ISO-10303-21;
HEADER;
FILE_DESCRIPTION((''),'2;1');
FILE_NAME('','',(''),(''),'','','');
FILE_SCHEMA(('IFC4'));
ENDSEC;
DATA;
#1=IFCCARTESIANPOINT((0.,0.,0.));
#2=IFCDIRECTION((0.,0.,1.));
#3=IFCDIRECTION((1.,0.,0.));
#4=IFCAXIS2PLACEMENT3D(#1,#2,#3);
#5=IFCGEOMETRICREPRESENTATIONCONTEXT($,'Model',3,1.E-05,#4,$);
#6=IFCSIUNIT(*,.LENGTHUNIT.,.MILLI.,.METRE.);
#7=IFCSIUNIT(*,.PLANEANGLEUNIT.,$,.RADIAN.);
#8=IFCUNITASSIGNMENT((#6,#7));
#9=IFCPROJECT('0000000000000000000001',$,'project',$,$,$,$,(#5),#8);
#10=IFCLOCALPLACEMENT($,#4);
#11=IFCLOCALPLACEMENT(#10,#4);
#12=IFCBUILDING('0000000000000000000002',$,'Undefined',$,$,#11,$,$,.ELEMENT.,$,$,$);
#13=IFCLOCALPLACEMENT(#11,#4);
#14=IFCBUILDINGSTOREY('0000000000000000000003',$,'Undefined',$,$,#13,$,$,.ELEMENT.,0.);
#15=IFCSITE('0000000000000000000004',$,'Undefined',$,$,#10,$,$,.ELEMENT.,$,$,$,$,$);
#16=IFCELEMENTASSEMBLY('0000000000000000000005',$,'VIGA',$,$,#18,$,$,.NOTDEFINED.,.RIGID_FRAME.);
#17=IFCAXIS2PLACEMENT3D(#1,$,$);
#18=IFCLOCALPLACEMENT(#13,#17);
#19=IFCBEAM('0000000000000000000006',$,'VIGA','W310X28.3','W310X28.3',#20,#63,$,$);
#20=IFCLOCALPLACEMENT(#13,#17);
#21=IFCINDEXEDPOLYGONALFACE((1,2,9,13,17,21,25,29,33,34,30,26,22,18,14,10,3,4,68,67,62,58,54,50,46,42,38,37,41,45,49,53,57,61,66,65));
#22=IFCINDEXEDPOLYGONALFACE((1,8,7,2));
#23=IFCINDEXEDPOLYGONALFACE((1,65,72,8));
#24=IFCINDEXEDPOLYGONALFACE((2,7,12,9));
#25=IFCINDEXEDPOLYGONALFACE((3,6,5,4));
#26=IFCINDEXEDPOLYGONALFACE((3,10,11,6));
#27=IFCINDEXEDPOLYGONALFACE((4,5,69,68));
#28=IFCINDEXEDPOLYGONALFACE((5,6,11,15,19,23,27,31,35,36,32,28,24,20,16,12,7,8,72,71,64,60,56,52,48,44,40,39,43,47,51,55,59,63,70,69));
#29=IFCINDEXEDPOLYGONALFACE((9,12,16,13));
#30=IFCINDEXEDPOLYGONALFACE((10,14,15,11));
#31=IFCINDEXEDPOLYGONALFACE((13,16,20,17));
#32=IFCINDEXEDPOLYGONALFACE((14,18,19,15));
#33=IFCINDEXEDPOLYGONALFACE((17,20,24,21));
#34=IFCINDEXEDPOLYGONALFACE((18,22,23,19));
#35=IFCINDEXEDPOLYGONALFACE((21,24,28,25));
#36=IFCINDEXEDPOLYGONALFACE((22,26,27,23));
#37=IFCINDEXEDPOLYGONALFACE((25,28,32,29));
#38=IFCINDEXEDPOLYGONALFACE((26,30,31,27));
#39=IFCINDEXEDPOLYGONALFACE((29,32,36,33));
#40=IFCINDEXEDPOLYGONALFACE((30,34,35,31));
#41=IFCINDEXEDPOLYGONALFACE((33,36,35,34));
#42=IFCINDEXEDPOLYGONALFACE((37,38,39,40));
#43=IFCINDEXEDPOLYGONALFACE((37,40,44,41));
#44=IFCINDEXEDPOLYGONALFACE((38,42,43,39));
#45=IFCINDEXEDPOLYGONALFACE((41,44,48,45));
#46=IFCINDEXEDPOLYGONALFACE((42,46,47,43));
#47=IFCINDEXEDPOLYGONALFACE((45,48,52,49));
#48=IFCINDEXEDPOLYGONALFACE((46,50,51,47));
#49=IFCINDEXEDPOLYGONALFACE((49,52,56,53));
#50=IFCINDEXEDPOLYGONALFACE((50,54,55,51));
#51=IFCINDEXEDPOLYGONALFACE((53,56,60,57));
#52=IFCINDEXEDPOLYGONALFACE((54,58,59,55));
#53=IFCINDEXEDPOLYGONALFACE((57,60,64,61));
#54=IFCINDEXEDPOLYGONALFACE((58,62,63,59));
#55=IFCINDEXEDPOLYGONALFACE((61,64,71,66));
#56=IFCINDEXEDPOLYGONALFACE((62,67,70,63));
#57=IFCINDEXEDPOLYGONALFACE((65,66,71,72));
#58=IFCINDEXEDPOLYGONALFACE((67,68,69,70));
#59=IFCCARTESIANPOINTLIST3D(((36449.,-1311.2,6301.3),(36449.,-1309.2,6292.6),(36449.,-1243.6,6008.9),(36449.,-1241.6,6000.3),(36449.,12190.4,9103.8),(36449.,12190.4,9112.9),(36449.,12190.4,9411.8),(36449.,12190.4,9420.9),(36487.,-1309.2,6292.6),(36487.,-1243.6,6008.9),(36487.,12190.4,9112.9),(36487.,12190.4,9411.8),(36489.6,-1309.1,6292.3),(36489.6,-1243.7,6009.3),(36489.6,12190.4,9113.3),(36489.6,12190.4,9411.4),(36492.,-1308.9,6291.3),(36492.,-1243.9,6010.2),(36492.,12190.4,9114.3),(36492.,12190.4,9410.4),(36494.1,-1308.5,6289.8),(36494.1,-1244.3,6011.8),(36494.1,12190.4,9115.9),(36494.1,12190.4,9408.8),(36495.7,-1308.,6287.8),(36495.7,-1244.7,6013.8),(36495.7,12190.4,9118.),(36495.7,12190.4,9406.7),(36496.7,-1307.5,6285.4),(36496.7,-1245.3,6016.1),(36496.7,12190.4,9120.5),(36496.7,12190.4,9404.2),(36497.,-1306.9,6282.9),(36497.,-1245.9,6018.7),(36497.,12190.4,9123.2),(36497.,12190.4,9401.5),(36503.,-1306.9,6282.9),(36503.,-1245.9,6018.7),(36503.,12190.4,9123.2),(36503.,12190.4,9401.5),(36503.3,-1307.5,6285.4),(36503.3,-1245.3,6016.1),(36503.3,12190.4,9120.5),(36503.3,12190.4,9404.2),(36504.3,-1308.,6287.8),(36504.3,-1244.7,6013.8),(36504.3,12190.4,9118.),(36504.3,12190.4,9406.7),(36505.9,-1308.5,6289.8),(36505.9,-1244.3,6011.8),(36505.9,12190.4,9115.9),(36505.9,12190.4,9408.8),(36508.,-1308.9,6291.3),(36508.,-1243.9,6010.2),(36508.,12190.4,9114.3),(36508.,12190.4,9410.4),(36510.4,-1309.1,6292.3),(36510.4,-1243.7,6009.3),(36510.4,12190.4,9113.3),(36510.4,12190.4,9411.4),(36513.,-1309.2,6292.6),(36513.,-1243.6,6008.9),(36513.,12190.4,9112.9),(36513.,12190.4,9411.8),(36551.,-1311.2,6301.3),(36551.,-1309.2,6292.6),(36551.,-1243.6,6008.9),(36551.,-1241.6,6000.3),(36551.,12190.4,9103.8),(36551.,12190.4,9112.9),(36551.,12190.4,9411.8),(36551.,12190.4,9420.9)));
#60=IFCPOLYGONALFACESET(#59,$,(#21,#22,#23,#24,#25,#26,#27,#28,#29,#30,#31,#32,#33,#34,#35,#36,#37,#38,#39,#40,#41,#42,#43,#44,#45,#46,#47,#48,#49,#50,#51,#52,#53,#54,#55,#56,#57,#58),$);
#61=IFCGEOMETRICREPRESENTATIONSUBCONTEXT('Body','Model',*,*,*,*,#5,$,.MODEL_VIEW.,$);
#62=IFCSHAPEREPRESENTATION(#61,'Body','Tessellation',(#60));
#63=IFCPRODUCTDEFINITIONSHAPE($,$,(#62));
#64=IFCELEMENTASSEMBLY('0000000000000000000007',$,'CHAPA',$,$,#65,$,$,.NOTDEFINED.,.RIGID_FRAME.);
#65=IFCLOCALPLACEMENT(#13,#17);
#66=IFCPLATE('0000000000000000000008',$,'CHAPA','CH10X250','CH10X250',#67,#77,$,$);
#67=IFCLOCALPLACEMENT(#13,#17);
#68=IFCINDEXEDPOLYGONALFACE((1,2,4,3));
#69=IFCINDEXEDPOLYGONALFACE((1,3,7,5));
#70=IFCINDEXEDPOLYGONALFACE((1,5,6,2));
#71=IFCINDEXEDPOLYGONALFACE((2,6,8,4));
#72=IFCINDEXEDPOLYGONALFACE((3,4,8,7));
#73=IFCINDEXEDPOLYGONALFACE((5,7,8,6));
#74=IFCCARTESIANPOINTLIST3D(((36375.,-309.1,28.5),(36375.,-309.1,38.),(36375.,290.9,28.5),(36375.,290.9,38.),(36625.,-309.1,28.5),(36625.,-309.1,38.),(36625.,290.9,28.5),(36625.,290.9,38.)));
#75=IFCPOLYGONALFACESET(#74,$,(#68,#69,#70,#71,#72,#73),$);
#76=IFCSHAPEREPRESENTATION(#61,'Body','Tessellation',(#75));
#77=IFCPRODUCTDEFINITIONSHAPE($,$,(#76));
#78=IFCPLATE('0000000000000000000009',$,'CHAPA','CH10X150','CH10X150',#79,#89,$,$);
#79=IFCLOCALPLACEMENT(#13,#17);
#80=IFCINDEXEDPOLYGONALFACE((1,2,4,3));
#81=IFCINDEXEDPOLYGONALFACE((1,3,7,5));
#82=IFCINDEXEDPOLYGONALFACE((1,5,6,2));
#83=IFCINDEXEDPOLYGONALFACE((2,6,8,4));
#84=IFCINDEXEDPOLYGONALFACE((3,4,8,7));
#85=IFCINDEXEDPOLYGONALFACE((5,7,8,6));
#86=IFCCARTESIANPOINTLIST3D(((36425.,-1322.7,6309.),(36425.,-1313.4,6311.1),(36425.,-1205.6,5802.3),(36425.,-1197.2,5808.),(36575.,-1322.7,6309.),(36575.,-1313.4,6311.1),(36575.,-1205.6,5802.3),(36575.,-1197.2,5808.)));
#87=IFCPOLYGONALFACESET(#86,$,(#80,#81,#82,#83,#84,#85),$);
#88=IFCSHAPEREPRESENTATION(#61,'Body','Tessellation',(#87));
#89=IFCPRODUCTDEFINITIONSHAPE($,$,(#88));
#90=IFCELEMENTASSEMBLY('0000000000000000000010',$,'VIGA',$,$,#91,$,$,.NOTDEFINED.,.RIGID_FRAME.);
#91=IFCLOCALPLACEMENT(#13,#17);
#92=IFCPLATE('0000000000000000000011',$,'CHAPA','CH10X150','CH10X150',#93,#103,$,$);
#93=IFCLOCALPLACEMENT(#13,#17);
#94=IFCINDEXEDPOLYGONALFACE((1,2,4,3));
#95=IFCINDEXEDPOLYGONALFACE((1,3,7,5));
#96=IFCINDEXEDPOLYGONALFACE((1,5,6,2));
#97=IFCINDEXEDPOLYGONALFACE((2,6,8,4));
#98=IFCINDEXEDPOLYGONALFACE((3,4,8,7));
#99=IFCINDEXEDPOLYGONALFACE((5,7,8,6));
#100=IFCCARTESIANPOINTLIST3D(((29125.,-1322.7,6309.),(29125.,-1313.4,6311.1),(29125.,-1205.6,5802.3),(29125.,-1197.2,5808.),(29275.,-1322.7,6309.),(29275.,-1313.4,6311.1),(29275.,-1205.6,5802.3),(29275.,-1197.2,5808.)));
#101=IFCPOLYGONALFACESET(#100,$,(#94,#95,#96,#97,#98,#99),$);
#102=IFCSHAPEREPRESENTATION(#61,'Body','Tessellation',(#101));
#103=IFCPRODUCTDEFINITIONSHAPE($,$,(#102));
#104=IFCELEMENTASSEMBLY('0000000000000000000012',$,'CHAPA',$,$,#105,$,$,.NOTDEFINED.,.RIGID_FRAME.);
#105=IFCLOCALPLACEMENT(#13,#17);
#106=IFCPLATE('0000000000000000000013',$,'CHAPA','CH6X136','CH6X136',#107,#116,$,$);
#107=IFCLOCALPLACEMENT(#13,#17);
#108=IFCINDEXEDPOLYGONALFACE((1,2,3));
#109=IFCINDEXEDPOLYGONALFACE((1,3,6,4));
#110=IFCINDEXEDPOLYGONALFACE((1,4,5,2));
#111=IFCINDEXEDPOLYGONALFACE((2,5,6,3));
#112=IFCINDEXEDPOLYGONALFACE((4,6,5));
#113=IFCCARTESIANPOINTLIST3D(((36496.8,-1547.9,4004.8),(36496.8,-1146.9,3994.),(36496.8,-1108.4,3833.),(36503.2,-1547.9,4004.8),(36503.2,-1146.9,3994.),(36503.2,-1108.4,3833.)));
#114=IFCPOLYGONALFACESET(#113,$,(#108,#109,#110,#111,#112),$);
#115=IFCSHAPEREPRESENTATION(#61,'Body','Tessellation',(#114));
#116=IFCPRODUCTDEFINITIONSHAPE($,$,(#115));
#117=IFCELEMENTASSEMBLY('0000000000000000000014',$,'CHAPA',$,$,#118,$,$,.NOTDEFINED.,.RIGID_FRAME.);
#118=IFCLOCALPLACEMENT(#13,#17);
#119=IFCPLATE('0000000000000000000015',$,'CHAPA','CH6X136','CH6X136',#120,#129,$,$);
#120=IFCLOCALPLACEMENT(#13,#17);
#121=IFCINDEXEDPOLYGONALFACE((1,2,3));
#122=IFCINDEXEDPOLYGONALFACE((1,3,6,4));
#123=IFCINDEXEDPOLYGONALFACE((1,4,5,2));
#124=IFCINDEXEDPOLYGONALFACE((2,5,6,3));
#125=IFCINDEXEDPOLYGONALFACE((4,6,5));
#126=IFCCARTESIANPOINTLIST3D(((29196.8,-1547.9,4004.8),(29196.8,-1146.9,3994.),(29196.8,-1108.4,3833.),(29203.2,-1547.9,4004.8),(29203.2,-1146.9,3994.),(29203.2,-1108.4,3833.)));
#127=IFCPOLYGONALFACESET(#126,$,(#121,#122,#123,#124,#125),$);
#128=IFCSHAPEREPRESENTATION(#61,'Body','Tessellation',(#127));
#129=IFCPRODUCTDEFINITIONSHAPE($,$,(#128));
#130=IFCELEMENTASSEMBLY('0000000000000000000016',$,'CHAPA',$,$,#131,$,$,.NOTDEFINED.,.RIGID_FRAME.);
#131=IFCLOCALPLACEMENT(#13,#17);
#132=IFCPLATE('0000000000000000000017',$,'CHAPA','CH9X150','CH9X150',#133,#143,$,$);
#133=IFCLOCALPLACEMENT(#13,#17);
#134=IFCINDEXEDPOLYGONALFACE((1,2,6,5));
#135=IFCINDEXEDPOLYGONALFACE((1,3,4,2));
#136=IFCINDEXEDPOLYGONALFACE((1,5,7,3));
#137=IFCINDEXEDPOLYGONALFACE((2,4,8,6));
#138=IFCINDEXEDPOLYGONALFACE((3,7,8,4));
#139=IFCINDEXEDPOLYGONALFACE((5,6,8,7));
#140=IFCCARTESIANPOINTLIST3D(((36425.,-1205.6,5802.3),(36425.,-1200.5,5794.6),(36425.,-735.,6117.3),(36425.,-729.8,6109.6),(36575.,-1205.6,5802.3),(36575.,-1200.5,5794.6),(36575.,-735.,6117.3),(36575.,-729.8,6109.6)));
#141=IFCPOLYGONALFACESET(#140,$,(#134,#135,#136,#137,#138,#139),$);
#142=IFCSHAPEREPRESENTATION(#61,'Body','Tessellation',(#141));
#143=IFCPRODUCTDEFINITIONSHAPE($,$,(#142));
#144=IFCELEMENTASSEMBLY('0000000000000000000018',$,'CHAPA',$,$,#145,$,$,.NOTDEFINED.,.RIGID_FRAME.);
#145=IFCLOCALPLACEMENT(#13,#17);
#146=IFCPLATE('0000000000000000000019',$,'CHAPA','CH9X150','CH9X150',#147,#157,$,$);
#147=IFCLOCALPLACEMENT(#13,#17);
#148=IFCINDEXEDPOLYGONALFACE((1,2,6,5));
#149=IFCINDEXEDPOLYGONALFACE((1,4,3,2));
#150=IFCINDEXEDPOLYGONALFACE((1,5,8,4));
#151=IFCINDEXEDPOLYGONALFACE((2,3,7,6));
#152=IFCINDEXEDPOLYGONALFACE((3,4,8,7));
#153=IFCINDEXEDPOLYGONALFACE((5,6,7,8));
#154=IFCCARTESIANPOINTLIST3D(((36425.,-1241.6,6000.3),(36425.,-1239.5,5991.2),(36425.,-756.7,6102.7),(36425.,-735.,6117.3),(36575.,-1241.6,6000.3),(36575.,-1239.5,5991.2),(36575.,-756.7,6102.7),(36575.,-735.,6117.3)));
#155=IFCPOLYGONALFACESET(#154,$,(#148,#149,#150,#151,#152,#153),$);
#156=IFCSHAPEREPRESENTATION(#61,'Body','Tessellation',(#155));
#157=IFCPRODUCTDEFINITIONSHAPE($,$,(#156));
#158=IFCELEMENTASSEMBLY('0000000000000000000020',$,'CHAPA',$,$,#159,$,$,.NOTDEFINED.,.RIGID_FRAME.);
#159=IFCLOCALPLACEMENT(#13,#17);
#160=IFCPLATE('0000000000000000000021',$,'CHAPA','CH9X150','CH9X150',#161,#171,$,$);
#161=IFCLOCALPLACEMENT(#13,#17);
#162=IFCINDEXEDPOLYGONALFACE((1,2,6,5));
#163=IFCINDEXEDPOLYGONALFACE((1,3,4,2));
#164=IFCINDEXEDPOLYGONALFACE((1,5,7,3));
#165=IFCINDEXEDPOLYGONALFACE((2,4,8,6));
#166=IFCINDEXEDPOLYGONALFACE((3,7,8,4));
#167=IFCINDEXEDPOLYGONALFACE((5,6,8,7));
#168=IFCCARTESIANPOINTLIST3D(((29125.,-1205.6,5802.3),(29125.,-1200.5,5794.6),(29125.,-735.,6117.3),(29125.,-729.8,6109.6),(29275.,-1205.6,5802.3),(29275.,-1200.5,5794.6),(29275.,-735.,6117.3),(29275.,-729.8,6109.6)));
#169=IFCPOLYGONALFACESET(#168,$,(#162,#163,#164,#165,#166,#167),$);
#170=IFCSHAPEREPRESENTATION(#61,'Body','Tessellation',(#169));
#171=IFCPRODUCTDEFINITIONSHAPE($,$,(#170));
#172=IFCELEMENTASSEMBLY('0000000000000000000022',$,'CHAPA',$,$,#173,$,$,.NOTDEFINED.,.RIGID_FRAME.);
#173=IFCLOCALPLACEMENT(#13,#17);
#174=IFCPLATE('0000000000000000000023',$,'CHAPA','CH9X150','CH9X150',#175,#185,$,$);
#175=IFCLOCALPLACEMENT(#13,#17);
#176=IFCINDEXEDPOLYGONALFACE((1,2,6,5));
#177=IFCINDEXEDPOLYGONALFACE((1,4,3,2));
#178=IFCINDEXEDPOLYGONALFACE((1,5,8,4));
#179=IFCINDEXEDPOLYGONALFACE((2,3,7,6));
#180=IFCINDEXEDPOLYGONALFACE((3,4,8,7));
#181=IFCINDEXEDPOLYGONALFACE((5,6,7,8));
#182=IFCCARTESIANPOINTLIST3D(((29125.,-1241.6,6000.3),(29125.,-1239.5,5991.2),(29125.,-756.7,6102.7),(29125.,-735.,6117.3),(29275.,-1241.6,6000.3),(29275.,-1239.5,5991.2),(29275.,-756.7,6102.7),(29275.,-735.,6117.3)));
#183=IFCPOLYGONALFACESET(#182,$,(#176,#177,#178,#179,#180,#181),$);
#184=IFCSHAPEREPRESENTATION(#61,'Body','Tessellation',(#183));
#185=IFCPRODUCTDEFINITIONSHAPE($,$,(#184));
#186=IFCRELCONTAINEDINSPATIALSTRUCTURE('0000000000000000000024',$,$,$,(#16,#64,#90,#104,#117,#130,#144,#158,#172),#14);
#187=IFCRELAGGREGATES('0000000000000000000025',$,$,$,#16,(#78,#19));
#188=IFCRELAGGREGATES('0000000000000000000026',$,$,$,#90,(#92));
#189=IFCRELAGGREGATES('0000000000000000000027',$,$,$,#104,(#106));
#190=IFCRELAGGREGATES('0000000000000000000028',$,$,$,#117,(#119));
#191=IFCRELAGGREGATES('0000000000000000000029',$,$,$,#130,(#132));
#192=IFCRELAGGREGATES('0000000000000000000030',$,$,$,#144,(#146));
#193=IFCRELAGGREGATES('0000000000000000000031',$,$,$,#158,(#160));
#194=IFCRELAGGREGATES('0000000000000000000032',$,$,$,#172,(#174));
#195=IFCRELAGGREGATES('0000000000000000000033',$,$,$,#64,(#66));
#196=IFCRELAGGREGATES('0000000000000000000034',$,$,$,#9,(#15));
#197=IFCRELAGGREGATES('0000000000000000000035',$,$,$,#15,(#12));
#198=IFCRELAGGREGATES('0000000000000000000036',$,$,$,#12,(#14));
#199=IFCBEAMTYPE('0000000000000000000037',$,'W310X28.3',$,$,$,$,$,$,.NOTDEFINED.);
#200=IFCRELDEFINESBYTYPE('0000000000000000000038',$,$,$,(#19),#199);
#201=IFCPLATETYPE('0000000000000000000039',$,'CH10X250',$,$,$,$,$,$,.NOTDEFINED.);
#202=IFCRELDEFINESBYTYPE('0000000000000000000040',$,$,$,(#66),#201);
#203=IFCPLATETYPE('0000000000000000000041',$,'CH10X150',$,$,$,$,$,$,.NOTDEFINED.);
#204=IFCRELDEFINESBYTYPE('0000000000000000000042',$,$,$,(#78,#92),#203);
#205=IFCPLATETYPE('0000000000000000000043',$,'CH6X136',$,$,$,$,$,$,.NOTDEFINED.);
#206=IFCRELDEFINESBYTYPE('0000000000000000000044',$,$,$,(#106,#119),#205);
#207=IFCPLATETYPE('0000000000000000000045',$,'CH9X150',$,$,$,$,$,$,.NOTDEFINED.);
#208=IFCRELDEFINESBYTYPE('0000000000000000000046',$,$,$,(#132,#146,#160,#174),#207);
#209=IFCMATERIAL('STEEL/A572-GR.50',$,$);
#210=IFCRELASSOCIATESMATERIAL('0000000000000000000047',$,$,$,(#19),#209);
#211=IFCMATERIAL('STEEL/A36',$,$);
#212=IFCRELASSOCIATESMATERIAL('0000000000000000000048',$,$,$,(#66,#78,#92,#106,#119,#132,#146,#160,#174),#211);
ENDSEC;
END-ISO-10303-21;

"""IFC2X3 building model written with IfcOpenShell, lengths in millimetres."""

from ifc_helpers import new_model, si_unit, frame, origin_with_axes, origin_2d_with_axis, place, context, subcontext, project, spatial, polyline, i_section, outline, extrude, clip, halfspace, material, type_object, element, aggregate, save


model = new_model("IFC2X3")

# Units and contexts
model_context = context("Model", 3, precision=1e-05, world=origin_with_axes())
body_context = subcontext(model_context, "Body", "Model", "MODEL_VIEW")
ifc_project = project(units=[si_unit("LENGTHUNIT", "METRE", prefix="MILLI"), si_unit("PLANEANGLEUNIT", "RADIAN")], contexts=[model_context])

# Site, building, storey
site_placement = place(None, origin_with_axes())
site = spatial("IfcSite", under=ifc_project, at=site_placement, Name="Undefined", CompositionType="ELEMENT")
building_placement = place(site_placement, origin_with_axes())
building = spatial("IfcBuilding", under=site, at=building_placement, Name="Undefined", CompositionType="ELEMENT")
storey_placement = place(building_placement, origin_with_axes())
storey = spatial("IfcBuildingStorey", under=building, at=storey_placement, Name="Undefined", CompositionType="ELEMENT", Elevation=0.0)

# Element assembly, beam
assembly_1_placement = place(storey_placement, origin_with_axes())
assembly_1 = element("IfcElementAssembly", 1, at=assembly_1_placement, inside=storey, Name="VIGA", AssemblyPlace="NOTDEFINED", PredefinedType="RIGID_FRAME")
ifc_material_1 = material(Name="STEEL/A572-GR.50")
beam_type_1 = type_object("IfcBeamType", Name="W310X28.3", PredefinedType="NOTDEFINED")
beam_1_placement = place(assembly_1_placement, frame((36500.0, -1276.4, 6150.8), z_axis=(0.0, 0.225124, -0.97433), x_axis=(0.0, 0.97433, 0.225124)))
beam_1 = element("IfcBeam", 2, at=beam_1_placement, type_object=beam_type_1, material=ifc_material_1, Name="VIGA", Description="W310X28.3", ObjectType="W310X28.3", context=body_context, shape_type="Clipping", body=[
    clip(extrude(i_section(OverallWidth=102.0, OverallDepth=309.0, WebThickness=6.0, FlangeThickness=8.9, FilletRadius=10.0, at=origin_2d_with_axis()), frame((13995.7, 0.0, 0.0), z_axis=(-1.0, 0.0, 0.0), x_axis=(0.0, -1.0, 0.0)), (0.0, 0.0, 1.0), 13995.7), halfspace(frame((13857.8, 0.0, -156.7), z_axis=(0.97433, 0.0, 0.225124), x_axis=(-0.225124, 0.0, 0.97433)), False)),
])

# Element assembly, plate
assembly_2_placement = place(storey_placement, origin_with_axes())
assembly_2 = element("IfcElementAssembly", 3, at=assembly_2_placement, inside=storey, Name="CHAPA", AssemblyPlace="NOTDEFINED", PredefinedType="RIGID_FRAME")
ifc_material_2 = material(Name="STEEL/A36")
plate_type_1 = type_object("IfcPlateType", Name="CH10X250", PredefinedType="NOTDEFINED")
plate_1_placement = place(assembly_2_placement, frame((36375.0, -309.1, 33.2), z_axis=(0.0, 0.0, 1.0), x_axis=(1.0, 0.0, 0.0)))
plate_1 = element("IfcPlate", 4, at=plate_1_placement, type_object=plate_type_1, material=ifc_material_2, Name="CHAPA", Description="CH10X250", ObjectType="CH10X250", context=body_context, shape_type="SweptSolid", body=[
    extrude(outline(polyline([(0.0, 0.0), (250.0, 0.0), (250.0, 600.0), (0.0, 600.0), (0.0, 0.0)])), frame((0.0, 0.0, -4.8), z_axis=(0.0, 0.0, 1.0), x_axis=(1.0, 0.0, 0.0)), (0.0, 0.0, 1.0), 9.5),
])

# Plate
plate_type_2 = type_object("IfcPlateType", Name="CH10X150", PredefinedType="NOTDEFINED")
plate_2_placement = place(assembly_1_placement, frame((36575.0, -1318.1, 6310.1), z_axis=(0.0, 0.97433, 0.225124), x_axis=(0.0, 0.225124, -0.97433)))
plate_2 = element("IfcPlate", 5, at=plate_2_placement, type_object=plate_type_2, material=ifc_material_2, Name="CHAPA", Description="CH10X150", ObjectType="CH10X150", context=body_context, shape_type="Clipping", body=[
    clip(extrude(outline(polyline([(0.0, 0.0), (520.0, 0.0), (520.0, 150.0), (0.0, 150.0), (0.0, 0.0)])), frame((0.0, 0.0, -4.8), z_axis=(0.0, 0.0, 1.0), x_axis=(1.0, 0.0, 0.0)), (0.0, 0.0, 1.0), 9.5), halfspace(frame((516.4, -500.0, 4.8), z_axis=(0.934951, 0.0, 0.354778), x_axis=(0.0, 1.0, 0.0)), False)),
])
aggregate(assembly_1, [plate_2, beam_1])

# Element assemblies, plates
assembly_3_placement = place(storey_placement, origin_with_axes())
assembly_3 = element("IfcElementAssembly", 6, at=assembly_3_placement, inside=storey, Name="VIGA", AssemblyPlace="NOTDEFINED", PredefinedType="RIGID_FRAME")
plate_3_placement = place(assembly_3_placement, frame((29275.0, -1318.1, 6310.1), z_axis=(0.0, 0.97433, 0.225124), x_axis=(0.0, 0.225124, -0.97433)))
plate_3 = element("IfcPlate", 7, at=plate_3_placement, type_object=plate_type_2, material=ifc_material_2, Name="CHAPA", Description="CH10X150", ObjectType="CH10X150", context=body_context, shape_type="Clipping", body=[
    clip(extrude(outline(polyline([(0.0, 0.0), (520.0, 0.0), (520.0, 150.0), (0.0, 150.0), (0.0, 0.0)])), frame((0.0, 0.0, -4.8), z_axis=(0.0, 0.0, 1.0), x_axis=(1.0, 0.0, 0.0)), (0.0, 0.0, 1.0), 9.5), halfspace(frame((516.4, -500.0, 4.8), z_axis=(0.934951, 0.0, 0.354778), x_axis=(0.0, 1.0, 0.0)), False)),
])
aggregate(assembly_3, [plate_3])
assembly_4_placement = place(storey_placement, origin_with_axes())
assembly_4 = element("IfcElementAssembly", 8, at=assembly_4_placement, inside=storey, Name="CHAPA", AssemblyPlace="NOTDEFINED", PredefinedType="RIGID_FRAME")
plate_type_3 = type_object("IfcPlateType", Name="CH6X136", PredefinedType="NOTDEFINED")
plate_4_placement = place(assembly_4_placement, frame((36500.0, -1146.9, 3994.0), z_axis=(1.0, 0.0, 0.0), x_axis=(0.0, -0.999636, 0.026972)))
plate_4 = element("IfcPlate", 9, at=plate_4_placement, type_object=plate_type_3, material=ifc_material_2, Name="CHAPA", Description="CH6X136", ObjectType="CH6X136", context=body_context, shape_type="SweptSolid", body=[
    extrude(outline(polyline([(0.0, 0.0), (401.1, 0.0), (-42.8, 159.9), (0.0, 0.0)])), frame((0.0, 0.0, -3.1), z_axis=(0.0, 0.0, 1.0), x_axis=(1.0, 0.0, 0.0)), (0.0, 0.0, 1.0), 6.3),
])
aggregate(assembly_4, [plate_4])
assembly_5_placement = place(storey_placement, origin_with_axes())
assembly_5 = element("IfcElementAssembly", 10, at=assembly_5_placement, inside=storey, Name="CHAPA", AssemblyPlace="NOTDEFINED", PredefinedType="RIGID_FRAME")
plate_5_placement = place(assembly_5_placement, frame((29200.0, -1146.9, 3994.0), z_axis=(1.0, 0.0, 0.0), x_axis=(0.0, -0.999636, 0.026972)))
plate_5 = element("IfcPlate", 11, at=plate_5_placement, type_object=plate_type_3, material=ifc_material_2, Name="CHAPA", Description="CH6X136", ObjectType="CH6X136", context=body_context, shape_type="SweptSolid", body=[
    extrude(outline(polyline([(0.0, 0.0), (401.1, 0.0), (-42.8, 159.9), (0.0, 0.0)])), frame((0.0, 0.0, -3.1), z_axis=(0.0, 0.0, 1.0), x_axis=(1.0, 0.0, 0.0)), (0.0, 0.0, 1.0), 6.3),
])
aggregate(assembly_5, [plate_5])
assembly_6_placement = place(storey_placement, origin_with_axes())
assembly_6 = element("IfcElementAssembly", 12, at=assembly_6_placement, inside=storey, Name="CHAPA", AssemblyPlace="NOTDEFINED", PredefinedType="RIGID_FRAME")
plate_type_4 = type_object("IfcPlateType", Name="CH9X150", PredefinedType="NOTDEFINED")
plate_6_placement = place(assembly_6_placement, frame((36575.0, -732.4, 6113.5), z_axis=(0.0, -0.55615, 0.831082), x_axis=(-1.0, 0.0, 0.0)))
plate_6 = element("IfcPlate", 13, at=plate_6_placement, type_object=plate_type_4, material=ifc_material_2, Name="CHAPA", Description="CH9X150", ObjectType="CH9X150", context=body_context, shape_type="SweptSolid", body=[
    extrude(outline(polyline([(0.0, 0.0), (150.0, 0.0), (150.0, 566.3), (0.0, 566.3), (0.0, 0.0)])), frame((0.0, 0.0, -4.7), z_axis=(0.0, 0.0, 1.0), x_axis=(1.0, 0.0, 0.0)), (0.0, 0.0, 1.0), 9.3),
])
aggregate(assembly_6, [plate_6])
assembly_7_placement = place(storey_placement, origin_with_axes())
assembly_7 = element("IfcElementAssembly", 14, at=assembly_7_placement, inside=storey, Name="CHAPA", AssemblyPlace="NOTDEFINED", PredefinedType="RIGID_FRAME")
plate_7_placement = place(assembly_7_placement, frame((36575.0, -1240.6, 5995.7), z_axis=(0.0, -0.225124, 0.97433), x_axis=(0.0, 0.97433, 0.225124)))
plate_7 = element("IfcPlate", 15, at=plate_7_placement, type_object=plate_type_4, material=ifc_material_2, Name="CHAPA", Description="CH9X150", ObjectType="CH9X150", context=body_context, shape_type="Clipping", body=[
    clip(extrude(outline(polyline([(0.0, 0.0), (520.0, 0.0), (520.0, 150.0), (0.0, 150.0), (0.0, 0.0)])), frame((0.0, 0.0, -4.7), z_axis=(0.0, 0.0, 1.0), x_axis=(1.0, 0.0, 0.0)), (0.0, 0.0, 1.0), 9.3), halfspace(frame((520.0, -500.0, 4.7), z_axis=(0.354778, 0.0, -0.934951), x_axis=(0.0, 1.0, 0.0)), False)),
])
aggregate(assembly_7, [plate_7])
assembly_8_placement = place(storey_placement, origin_with_axes())
assembly_8 = element("IfcElementAssembly", 16, at=assembly_8_placement, inside=storey, Name="CHAPA", AssemblyPlace="NOTDEFINED", PredefinedType="RIGID_FRAME")
plate_8_placement = place(assembly_8_placement, frame((29275.0, -732.4, 6113.5), z_axis=(0.0, -0.55615, 0.831082), x_axis=(-1.0, 0.0, 0.0)))
plate_8 = element("IfcPlate", 17, at=plate_8_placement, type_object=plate_type_4, material=ifc_material_2, Name="CHAPA", Description="CH9X150", ObjectType="CH9X150", context=body_context, shape_type="SweptSolid", body=[
    extrude(outline(polyline([(0.0, 0.0), (150.0, 0.0), (150.0, 566.3), (0.0, 566.3), (0.0, 0.0)])), frame((0.0, 0.0, -4.7), z_axis=(0.0, 0.0, 1.0), x_axis=(1.0, 0.0, 0.0)), (0.0, 0.0, 1.0), 9.3),
])
aggregate(assembly_8, [plate_8])
assembly_9_placement = place(storey_placement, origin_with_axes())
assembly_9 = element("IfcElementAssembly", 18, at=assembly_9_placement, inside=storey, Name="CHAPA", AssemblyPlace="NOTDEFINED", PredefinedType="RIGID_FRAME")
plate_9_placement = place(assembly_9_placement, frame((29275.0, -1240.6, 5995.7), z_axis=(0.0, -0.225124, 0.97433), x_axis=(0.0, 0.97433, 0.225124)))
plate_9 = element("IfcPlate", 19, at=plate_9_placement, type_object=plate_type_4, material=ifc_material_2, Name="CHAPA", Description="CH9X150", ObjectType="CH9X150", context=body_context, shape_type="Clipping", body=[
    clip(extrude(outline(polyline([(0.0, 0.0), (520.0, 0.0), (520.0, 150.0), (0.0, 150.0), (0.0, 0.0)])), frame((0.0, 0.0, -4.7), z_axis=(0.0, 0.0, 1.0), x_axis=(1.0, 0.0, 0.0)), (0.0, 0.0, 1.0), 9.3), halfspace(frame((520.0, -500.0, 4.7), z_axis=(0.354778, 0.0, -0.934951), x_axis=(0.0, 1.0, 0.0)), False)),
])
aggregate(assembly_9, [plate_9])

aggregate(assembly_2, [plate_1])

save(model, "model.ifc")
